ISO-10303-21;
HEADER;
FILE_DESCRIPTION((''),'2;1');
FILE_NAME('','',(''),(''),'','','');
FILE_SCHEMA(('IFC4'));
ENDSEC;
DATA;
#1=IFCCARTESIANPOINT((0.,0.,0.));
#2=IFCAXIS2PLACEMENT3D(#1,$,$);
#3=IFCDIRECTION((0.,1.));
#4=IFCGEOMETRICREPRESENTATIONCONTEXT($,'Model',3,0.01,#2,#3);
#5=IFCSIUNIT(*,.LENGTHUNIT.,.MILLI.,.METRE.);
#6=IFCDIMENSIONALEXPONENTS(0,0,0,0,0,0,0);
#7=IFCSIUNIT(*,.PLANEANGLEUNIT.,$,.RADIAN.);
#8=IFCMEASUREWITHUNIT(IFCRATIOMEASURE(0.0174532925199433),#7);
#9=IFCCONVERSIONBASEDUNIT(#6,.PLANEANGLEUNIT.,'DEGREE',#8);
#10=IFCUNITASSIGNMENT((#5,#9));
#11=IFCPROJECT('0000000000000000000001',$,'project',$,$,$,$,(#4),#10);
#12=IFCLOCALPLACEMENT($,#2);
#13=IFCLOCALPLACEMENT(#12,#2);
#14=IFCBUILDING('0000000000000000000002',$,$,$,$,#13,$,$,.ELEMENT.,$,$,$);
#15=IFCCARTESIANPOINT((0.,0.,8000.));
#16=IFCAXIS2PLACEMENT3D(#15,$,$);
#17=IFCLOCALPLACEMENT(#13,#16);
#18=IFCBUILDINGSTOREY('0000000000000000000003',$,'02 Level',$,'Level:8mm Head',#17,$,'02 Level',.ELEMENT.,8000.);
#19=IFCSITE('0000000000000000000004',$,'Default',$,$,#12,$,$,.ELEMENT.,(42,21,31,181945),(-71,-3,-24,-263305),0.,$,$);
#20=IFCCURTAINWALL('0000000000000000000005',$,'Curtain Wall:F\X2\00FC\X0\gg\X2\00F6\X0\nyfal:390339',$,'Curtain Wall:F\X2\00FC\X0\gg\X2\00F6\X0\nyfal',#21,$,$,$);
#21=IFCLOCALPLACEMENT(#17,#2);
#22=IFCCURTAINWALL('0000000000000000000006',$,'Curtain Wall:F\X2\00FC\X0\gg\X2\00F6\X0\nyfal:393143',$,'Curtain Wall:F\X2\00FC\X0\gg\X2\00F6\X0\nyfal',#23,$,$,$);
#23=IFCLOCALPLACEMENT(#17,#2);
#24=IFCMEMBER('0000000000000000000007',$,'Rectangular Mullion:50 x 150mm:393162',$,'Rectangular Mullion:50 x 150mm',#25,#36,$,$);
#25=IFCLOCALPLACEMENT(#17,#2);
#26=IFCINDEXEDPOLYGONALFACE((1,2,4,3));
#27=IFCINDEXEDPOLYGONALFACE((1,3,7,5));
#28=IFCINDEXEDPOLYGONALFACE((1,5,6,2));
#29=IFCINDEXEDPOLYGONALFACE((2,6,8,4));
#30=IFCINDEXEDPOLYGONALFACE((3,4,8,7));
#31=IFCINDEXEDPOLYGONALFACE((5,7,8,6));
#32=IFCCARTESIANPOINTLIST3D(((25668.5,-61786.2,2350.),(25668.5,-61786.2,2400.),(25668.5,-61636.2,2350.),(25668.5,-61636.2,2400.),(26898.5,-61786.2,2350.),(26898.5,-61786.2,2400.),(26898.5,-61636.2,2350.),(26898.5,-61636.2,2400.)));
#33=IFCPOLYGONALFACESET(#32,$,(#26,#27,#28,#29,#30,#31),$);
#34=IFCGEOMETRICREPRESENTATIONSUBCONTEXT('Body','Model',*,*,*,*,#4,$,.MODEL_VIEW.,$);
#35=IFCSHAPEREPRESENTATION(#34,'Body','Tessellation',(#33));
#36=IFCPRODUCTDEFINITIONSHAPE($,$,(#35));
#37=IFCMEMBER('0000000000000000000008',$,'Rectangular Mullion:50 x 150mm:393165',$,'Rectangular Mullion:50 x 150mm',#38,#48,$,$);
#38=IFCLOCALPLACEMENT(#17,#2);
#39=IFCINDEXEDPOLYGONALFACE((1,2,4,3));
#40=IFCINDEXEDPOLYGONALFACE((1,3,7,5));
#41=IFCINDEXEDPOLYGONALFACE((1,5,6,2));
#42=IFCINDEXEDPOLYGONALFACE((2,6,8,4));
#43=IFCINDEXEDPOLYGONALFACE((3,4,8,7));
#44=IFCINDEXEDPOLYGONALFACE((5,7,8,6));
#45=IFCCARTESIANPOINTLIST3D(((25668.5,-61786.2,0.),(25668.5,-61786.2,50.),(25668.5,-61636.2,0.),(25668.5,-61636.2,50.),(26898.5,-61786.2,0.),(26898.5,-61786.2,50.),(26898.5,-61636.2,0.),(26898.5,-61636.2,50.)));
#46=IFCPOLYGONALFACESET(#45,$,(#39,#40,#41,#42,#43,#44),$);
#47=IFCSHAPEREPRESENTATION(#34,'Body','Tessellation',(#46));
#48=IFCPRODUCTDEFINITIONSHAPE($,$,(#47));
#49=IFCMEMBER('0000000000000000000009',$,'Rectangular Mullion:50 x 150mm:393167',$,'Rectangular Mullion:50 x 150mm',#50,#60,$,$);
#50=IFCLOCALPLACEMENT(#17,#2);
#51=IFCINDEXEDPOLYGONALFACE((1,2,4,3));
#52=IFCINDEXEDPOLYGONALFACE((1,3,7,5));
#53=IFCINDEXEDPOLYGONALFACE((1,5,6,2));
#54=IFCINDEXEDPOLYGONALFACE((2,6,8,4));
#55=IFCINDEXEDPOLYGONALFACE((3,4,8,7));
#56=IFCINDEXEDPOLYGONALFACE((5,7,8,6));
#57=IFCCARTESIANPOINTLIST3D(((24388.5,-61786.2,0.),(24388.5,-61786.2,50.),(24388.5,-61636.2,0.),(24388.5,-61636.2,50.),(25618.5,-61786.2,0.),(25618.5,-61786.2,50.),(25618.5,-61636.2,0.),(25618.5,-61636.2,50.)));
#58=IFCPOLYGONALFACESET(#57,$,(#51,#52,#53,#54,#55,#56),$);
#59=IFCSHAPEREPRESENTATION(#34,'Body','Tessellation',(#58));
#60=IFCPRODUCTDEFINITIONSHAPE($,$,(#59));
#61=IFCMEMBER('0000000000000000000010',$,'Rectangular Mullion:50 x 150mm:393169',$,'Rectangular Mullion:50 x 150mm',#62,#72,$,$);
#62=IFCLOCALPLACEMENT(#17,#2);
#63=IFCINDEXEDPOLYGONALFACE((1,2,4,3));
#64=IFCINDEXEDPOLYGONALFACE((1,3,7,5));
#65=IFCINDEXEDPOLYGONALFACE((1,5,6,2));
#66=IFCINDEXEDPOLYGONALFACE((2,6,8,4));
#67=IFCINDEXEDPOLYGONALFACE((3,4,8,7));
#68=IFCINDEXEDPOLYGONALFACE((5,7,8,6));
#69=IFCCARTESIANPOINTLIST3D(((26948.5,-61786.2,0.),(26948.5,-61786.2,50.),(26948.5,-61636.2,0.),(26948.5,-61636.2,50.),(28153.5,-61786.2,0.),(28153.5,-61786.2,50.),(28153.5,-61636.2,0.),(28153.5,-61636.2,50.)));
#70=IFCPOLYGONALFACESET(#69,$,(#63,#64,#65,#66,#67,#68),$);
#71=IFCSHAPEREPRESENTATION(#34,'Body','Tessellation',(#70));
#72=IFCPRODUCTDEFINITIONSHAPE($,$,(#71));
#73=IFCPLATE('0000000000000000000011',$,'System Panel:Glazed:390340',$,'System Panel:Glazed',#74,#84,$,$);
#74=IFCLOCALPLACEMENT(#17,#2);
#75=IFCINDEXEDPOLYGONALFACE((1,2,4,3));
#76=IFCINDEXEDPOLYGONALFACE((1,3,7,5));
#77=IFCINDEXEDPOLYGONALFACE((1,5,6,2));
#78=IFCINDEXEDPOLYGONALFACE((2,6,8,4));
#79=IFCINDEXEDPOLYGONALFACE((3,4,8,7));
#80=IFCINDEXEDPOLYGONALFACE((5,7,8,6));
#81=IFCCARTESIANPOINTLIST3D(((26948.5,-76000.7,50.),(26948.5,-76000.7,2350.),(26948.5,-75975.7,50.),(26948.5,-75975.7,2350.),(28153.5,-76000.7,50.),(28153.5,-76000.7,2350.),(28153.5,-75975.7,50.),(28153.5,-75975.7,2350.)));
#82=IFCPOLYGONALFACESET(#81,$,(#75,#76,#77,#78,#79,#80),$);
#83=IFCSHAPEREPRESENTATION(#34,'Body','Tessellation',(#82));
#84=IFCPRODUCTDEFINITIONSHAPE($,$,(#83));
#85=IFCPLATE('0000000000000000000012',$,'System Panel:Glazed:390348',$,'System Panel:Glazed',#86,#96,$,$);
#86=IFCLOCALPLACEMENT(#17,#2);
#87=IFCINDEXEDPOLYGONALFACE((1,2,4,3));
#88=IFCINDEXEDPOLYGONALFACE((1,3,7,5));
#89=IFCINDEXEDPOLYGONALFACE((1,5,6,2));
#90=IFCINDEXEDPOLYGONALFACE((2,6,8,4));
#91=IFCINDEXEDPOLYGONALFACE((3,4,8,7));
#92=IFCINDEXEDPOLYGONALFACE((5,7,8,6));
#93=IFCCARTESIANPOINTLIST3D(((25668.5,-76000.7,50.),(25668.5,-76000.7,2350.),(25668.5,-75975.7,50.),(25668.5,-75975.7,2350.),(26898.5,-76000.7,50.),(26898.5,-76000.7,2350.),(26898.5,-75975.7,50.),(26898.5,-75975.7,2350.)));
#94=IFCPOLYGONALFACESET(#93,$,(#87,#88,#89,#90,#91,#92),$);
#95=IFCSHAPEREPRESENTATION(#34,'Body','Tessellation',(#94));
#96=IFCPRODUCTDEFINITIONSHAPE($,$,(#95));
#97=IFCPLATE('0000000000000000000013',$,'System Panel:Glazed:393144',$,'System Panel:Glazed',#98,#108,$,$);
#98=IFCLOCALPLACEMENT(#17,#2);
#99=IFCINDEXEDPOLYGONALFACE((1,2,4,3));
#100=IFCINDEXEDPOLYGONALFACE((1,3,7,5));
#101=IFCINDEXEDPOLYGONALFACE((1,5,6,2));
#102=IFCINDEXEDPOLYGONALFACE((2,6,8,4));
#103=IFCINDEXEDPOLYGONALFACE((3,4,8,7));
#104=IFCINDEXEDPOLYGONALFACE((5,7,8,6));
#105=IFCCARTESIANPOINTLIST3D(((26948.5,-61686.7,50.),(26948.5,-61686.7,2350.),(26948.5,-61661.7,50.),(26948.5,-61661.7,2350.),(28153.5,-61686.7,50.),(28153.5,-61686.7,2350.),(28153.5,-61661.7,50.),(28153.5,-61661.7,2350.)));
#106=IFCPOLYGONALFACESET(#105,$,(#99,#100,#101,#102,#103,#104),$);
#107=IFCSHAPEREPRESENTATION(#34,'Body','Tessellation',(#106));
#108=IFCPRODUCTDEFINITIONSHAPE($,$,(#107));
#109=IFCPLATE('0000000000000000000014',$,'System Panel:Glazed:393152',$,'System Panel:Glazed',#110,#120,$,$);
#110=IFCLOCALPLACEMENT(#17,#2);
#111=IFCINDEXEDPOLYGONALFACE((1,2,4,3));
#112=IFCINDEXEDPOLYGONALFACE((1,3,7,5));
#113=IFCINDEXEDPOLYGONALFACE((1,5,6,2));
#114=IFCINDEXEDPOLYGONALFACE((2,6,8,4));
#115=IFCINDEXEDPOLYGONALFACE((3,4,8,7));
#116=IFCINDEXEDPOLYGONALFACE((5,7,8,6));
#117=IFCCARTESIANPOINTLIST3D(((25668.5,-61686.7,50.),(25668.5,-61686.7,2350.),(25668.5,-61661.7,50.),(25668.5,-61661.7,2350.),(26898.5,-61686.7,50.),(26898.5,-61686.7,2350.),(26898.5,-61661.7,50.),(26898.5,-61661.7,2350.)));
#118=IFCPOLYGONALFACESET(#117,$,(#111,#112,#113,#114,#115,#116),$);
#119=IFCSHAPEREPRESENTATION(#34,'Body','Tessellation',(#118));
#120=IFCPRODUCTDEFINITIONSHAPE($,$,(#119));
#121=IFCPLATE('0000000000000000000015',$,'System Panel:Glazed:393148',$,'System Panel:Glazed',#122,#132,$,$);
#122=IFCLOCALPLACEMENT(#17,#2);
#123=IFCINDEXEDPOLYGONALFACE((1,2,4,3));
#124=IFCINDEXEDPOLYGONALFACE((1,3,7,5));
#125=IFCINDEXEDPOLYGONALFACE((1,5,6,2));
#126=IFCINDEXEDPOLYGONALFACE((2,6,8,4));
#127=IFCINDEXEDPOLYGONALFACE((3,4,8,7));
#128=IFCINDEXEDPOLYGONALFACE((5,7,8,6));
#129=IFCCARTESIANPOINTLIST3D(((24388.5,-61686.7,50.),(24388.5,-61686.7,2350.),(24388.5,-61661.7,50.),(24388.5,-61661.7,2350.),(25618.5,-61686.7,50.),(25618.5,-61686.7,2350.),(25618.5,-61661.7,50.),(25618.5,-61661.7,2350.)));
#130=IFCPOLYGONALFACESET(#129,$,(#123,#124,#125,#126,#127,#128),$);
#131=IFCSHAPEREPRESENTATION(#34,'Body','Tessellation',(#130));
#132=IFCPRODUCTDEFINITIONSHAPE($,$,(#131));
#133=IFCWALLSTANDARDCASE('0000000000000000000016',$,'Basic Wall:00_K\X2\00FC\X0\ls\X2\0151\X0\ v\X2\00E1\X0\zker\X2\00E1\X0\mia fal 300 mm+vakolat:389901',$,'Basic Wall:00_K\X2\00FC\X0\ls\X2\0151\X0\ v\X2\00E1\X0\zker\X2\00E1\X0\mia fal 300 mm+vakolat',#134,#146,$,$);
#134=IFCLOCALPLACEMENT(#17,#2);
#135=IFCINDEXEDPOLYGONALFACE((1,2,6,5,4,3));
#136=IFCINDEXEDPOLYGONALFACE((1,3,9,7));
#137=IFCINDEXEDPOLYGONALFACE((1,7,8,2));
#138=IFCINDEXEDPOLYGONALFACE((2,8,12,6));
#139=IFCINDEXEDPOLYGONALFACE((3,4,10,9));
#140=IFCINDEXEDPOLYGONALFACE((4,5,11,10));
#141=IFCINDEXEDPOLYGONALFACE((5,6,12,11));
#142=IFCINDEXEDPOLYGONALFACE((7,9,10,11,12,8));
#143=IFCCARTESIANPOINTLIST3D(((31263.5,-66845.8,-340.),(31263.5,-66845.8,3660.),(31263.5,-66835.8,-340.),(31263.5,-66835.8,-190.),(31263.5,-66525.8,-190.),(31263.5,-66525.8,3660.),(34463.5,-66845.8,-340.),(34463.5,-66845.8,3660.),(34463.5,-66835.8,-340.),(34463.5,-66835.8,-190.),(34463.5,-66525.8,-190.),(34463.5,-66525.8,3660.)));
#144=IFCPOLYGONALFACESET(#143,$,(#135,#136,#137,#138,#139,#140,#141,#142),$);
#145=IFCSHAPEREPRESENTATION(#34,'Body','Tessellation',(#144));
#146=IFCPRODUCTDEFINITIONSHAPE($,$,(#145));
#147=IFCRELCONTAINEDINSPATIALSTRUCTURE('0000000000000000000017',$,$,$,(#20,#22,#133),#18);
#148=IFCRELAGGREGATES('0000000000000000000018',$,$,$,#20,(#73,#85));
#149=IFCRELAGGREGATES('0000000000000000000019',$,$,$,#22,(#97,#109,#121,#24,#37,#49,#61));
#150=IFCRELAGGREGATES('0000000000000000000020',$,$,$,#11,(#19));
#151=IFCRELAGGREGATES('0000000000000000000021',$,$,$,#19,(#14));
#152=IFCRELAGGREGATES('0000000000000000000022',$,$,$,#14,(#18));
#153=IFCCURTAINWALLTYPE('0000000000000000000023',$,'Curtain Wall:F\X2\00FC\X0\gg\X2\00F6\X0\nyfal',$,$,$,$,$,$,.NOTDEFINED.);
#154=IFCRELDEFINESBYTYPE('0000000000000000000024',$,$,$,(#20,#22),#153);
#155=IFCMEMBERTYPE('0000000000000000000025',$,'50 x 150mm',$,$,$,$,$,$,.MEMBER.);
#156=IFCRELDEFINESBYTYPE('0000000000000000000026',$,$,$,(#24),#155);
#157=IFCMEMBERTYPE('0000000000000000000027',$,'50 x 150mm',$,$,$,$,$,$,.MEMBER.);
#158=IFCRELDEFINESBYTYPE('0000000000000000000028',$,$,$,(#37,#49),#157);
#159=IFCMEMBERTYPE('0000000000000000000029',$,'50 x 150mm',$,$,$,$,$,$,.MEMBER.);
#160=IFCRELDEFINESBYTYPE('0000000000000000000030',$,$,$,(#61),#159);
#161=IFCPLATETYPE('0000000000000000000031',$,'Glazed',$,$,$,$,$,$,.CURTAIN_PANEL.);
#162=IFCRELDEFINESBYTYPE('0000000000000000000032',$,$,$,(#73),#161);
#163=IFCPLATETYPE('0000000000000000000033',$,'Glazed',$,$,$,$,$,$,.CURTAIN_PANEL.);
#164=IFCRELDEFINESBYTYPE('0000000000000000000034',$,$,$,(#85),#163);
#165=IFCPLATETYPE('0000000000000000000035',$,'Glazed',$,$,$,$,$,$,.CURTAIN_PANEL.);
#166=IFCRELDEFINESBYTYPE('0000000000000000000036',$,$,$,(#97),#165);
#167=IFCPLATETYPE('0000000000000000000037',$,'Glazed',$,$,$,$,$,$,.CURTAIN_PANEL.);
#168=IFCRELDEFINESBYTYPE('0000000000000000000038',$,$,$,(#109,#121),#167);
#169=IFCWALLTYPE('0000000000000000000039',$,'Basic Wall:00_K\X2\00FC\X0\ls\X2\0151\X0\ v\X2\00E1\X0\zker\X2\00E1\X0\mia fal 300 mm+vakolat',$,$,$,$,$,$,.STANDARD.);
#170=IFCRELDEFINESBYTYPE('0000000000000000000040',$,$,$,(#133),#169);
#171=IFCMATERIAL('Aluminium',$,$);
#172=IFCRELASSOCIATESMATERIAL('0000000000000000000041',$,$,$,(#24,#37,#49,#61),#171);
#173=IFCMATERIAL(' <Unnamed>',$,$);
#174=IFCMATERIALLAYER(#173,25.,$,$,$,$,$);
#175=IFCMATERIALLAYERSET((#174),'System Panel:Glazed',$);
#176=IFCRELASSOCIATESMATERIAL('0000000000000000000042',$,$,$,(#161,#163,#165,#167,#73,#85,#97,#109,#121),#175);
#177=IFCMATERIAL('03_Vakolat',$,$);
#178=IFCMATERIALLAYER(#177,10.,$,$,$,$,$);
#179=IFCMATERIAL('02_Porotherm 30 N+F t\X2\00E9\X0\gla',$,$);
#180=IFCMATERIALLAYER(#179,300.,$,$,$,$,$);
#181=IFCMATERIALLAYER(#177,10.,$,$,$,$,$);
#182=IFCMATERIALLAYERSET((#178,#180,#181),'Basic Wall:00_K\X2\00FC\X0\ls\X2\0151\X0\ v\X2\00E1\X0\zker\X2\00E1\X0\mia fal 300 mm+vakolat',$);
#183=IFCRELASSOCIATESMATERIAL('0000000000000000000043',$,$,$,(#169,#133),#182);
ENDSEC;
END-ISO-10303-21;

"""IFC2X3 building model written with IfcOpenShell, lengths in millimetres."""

from ifc_helpers import new_model, entity, si_unit, converted_unit, direction, frame, frame_2d, origin, origin_2d_with_axis, place, context, subcontext, project, spatial, polyline, rectangle, extrude, clip, bounded_halfspace, source, transform, mapped, material, layer, layer_set, layer_usage, type_object, type_shapes, element, aggregate, save


model = new_model("IFC2X3")

# Units and contexts
model_context = context("Model", 3, precision=0.01, world=origin(), true_north=direction((0.0, 1.0)))
body_context = subcontext(model_context, "Body", "Model", "MODEL_VIEW")
ifc_project = project(units=[si_unit("LENGTHUNIT", "METRE", prefix="MILLI"), converted_unit("PLANEANGLEUNIT", "DEGREE", entity("IfcRatioMeasure", 0.0174532925199433), si_unit("PLANEANGLEUNIT", "RADIAN"), dimensions=[0, 0, 0, 0, 0, 0, 0])], contexts=[model_context])

# Site, building, storey
site_placement = place(None, origin())
site = spatial("IfcSite", under=ifc_project, at=site_placement, Name="Default", CompositionType="ELEMENT", RefLatitude=(42, 21, 31, 181945), RefLongitude=(-71, -3, -24, -263305), RefElevation=0.0)
building_placement = place(site_placement, origin())
building = spatial("IfcBuilding", under=site, at=building_placement, CompositionType="ELEMENT")
storey_placement = place(building_placement, frame((0.0, 0.0, 8000.0)))
storey = spatial("IfcBuildingStorey", under=building, at=storey_placement, Name="02 Level", ObjectType="Level:8mm Head", LongName="02 Level", CompositionType="ELEMENT", Elevation=8000.0)

# Curtain walls, members
curtain_wall_type = type_object("IfcCurtainWallType", Name="Curtain Wall:Függönyfal", PredefinedType="NOTDEFINED")
curtain_wall_1_placement = place(storey_placement, frame((0.0, 0.0, -8000.0)))
curtain_wall_1 = element("IfcCurtainWall", 1, at=curtain_wall_1_placement, inside=storey, type_object=curtain_wall_type, Name="Curtain Wall:Függönyfal:390339", ObjectType="Curtain Wall:Függönyfal")
ifc_material_1 = material(Name="Aluminium")
curtain_wall_2_placement = place(storey_placement, frame((0.0, 0.0, -8000.0)))
curtain_wall_2 = element("IfcCurtainWall", 2, at=curtain_wall_2_placement, inside=storey, type_object=curtain_wall_type, Name="Curtain Wall:Függönyfal:393143", ObjectType="Curtain Wall:Függönyfal")
member_type_1 = type_object("IfcMemberType", Name="50 x 150mm", PredefinedType="MEMBER")
shared_shape_1 = source(origin(), body_context, "Body", "SweptSolid", [
    extrude(rectangle(XDim=150.0, YDim=50.0, at=origin_2d_with_axis()), frame((-25.0, 0.0, -1230.0), z_axis=(0.0, 0.0, 1.0), x_axis=(0.0, -1.0, 0.0)), (0.0, 0.0, 1.0), 1230.0),
])
type_shapes(member_type_1, [shared_shape_1])
member_1_placement = place(storey_placement, frame((25668.5, -61711.2, 2400.0), z_axis=(-1.0, 0.0, 0.0), x_axis=(0.0, 0.0, 1.0)))
member_1 = element("IfcMember", 3, at=member_1_placement, type_object=member_type_1, material=ifc_material_1, Name="Rectangular Mullion:50 x 150mm:393162", ObjectType="Rectangular Mullion:50 x 150mm", context=body_context, shape_type="MappedRepresentation", body=[
    mapped(shared_shape_1, transform((0.0, 0.0, 0.0), scale=1.0)),
])
member_type_2 = type_object("IfcMemberType", Name="50 x 150mm", PredefinedType="MEMBER")
shared_shape_2 = source(origin(), body_context, "Body", "SweptSolid", [
    extrude(rectangle(XDim=150.0, YDim=50.0, at=origin_2d_with_axis()), frame((-25.0, 0.0, -1230.0), z_axis=(0.0, 0.0, 1.0), x_axis=(0.0, -1.0, 0.0)), (0.0, 0.0, 1.0), 1230.0),
])
type_shapes(member_type_2, [shared_shape_2])
member_2_placement = place(storey_placement, frame((26898.5, -61711.2, 0.0), z_axis=(1.0, 0.0, 0.0), x_axis=(0.0, 0.0, -1.0)))
member_2 = element("IfcMember", 4, at=member_2_placement, type_object=member_type_2, material=ifc_material_1, Name="Rectangular Mullion:50 x 150mm:393165", ObjectType="Rectangular Mullion:50 x 150mm", context=body_context, shape_type="MappedRepresentation", body=[
    mapped(shared_shape_2, transform((0.0, 0.0, 0.0), scale=1.0)),
])
member_3_placement = place(storey_placement, frame((25618.5, -61711.2, 0.0), z_axis=(1.0, 0.0, 0.0), x_axis=(0.0, 0.0, -1.0)))
member_3 = element("IfcMember", 5, at=member_3_placement, type_object=member_type_2, material=ifc_material_1, Name="Rectangular Mullion:50 x 150mm:393167", ObjectType="Rectangular Mullion:50 x 150mm", context=body_context, shape_type="MappedRepresentation", body=[
    mapped(shared_shape_2, transform((0.0, 0.0, 0.0), scale=1.0)),
])
member_type_3 = type_object("IfcMemberType", Name="50 x 150mm", PredefinedType="MEMBER")
shared_shape_3 = source(origin(), body_context, "Body", "SweptSolid", [
    extrude(rectangle(XDim=150.0, YDim=50.0, at=origin_2d_with_axis()), frame((-25.0, 0.0, -1205.0), z_axis=(0.0, 0.0, 1.0), x_axis=(0.0, -1.0, 0.0)), (0.0, 0.0, 1.0), 1205.0),
])
type_shapes(member_type_3, [shared_shape_3])
member_4_placement = place(storey_placement, frame((28153.5, -61711.2, 0.0), z_axis=(1.0, 0.0, 0.0), x_axis=(0.0, 0.0, -1.0)))
member_4 = element("IfcMember", 6, at=member_4_placement, type_object=member_type_3, material=ifc_material_1, Name="Rectangular Mullion:50 x 150mm:393169", ObjectType="Rectangular Mullion:50 x 150mm", context=body_context, shape_type="MappedRepresentation", body=[
    mapped(shared_shape_3, transform((0.0, 0.0, 0.0), scale=1.0)),
])

# Plates
ifc_material_2 = material(Name=" <Unnamed>")
ifc_layer_1 = layer(ifc_material_2, 25.0)
ifc_layer_set_1 = layer_set([ifc_layer_1], Name="System Panel:Glazed")
ifc_layer_usage_1 = layer_usage(ifc_layer_set_1, "AXIS3", "POSITIVE", 0.1)
plate_type_1 = type_object("IfcPlateType", Name="Glazed", PredefinedType="CURTAIN_PANEL", material=ifc_layer_set_1)
shared_shape_4 = source(origin(), body_context, "Body", "SweptSolid", [
    extrude(rectangle(XDim=25.0, YDim=1205.0, at=origin_2d_with_axis()), frame((602.5, 12.5, 0.0), z_axis=(0.0, 0.0, 1.0), x_axis=(0.0, 1.0, 0.0)), (0.0, 0.0, 1.0), 2300.0),
])
type_shapes(plate_type_1, [shared_shape_4])
plate_1_placement = place(curtain_wall_1_placement, frame((28153.5, -75975.7, 8050.0), z_axis=(0.0, 0.0, 1.0), x_axis=(-1.0, 0.0, 0.0)))
plate_1 = element("IfcPlate", 7, at=plate_1_placement, type_object=plate_type_1, material=ifc_layer_usage_1, Name="System Panel:Glazed:390340", ObjectType="System Panel:Glazed", context=body_context, shape_type="MappedRepresentation", body=[
    mapped(shared_shape_4, transform((0.0, 0.0, 0.0), scale=1.0)),
])
ifc_layer_usage_2 = layer_usage(ifc_layer_set_1, "AXIS3", "POSITIVE", 0.1)
plate_type_2 = type_object("IfcPlateType", Name="Glazed", PredefinedType="CURTAIN_PANEL", material=ifc_layer_set_1)
shared_shape_5 = source(origin(), body_context, "Body", "SweptSolid", [
    extrude(rectangle(XDim=25.0, YDim=1230.0, at=origin_2d_with_axis()), frame((615.0, 12.5, 0.0), z_axis=(0.0, 0.0, 1.0), x_axis=(0.0, 1.0, 0.0)), (0.0, 0.0, 1.0), 2300.0),
])
type_shapes(plate_type_2, [shared_shape_5])
plate_2_placement = place(curtain_wall_1_placement, frame((26898.5, -75975.7, 8050.0), z_axis=(0.0, 0.0, 1.0), x_axis=(-1.0, 0.0, 0.0)))
plate_2 = element("IfcPlate", 8, at=plate_2_placement, type_object=plate_type_2, material=ifc_layer_usage_2, Name="System Panel:Glazed:390348", ObjectType="System Panel:Glazed", context=body_context, shape_type="MappedRepresentation", body=[
    mapped(shared_shape_5, transform((0.0, 0.0, 0.0), scale=1.0)),
])
aggregate(curtain_wall_1, [plate_1, plate_2])
ifc_layer_usage_3 = layer_usage(ifc_layer_set_1, "AXIS3", "POSITIVE", 0.1)
plate_type_3 = type_object("IfcPlateType", Name="Glazed", PredefinedType="CURTAIN_PANEL", material=ifc_layer_set_1)
shared_shape_6 = source(origin(), body_context, "Body", "SweptSolid", [
    extrude(rectangle(XDim=25.0, YDim=1205.0, at=frame_2d((0.0, 0.0), x_axis=(1.0, 0.0))), frame((602.5, 12.5, 0.0), z_axis=(0.0, 0.0, 1.0), x_axis=(0.0, 1.0, 0.0)), (0.0, 0.0, 1.0), 2300.0),
])
type_shapes(plate_type_3, [shared_shape_6])
plate_3_placement = place(curtain_wall_2_placement, frame((28153.5, -61661.7, 8050.0), z_axis=(0.0, 0.0, 1.0), x_axis=(-1.0, 0.0, 0.0)))
plate_3 = element("IfcPlate", 9, at=plate_3_placement, type_object=plate_type_3, material=ifc_layer_usage_3, Name="System Panel:Glazed:393144", ObjectType="System Panel:Glazed", context=body_context, shape_type="MappedRepresentation", body=[
    mapped(shared_shape_6, transform((0.0, 0.0, 0.0), scale=1.0)),
])
ifc_layer_usage_4 = layer_usage(ifc_layer_set_1, "AXIS3", "POSITIVE", 0.1)
plate_type_4 = type_object("IfcPlateType", Name="Glazed", PredefinedType="CURTAIN_PANEL", material=ifc_layer_set_1)
shared_shape_7 = source(origin(), body_context, "Body", "SweptSolid", [
    extrude(rectangle(XDim=25.0, YDim=1230.0, at=frame_2d((0.0, 0.0), x_axis=(1.0, 0.0))), frame((615.0, 12.5, 0.0), z_axis=(0.0, 0.0, 1.0), x_axis=(0.0, 1.0, 0.0)), (0.0, 0.0, 1.0), 2300.0),
])
type_shapes(plate_type_4, [shared_shape_7])
plate_4_placement = place(curtain_wall_2_placement, frame((26898.5, -61661.7, 8050.0), z_axis=(0.0, 0.0, 1.0), x_axis=(-1.0, 0.0, 0.0)))
plate_4 = element("IfcPlate", 10, at=plate_4_placement, type_object=plate_type_4, material=ifc_layer_usage_4, Name="System Panel:Glazed:393152", ObjectType="System Panel:Glazed", context=body_context, shape_type="MappedRepresentation", body=[
    mapped(shared_shape_7, transform((0.0, 0.0, 0.0), scale=1.0)),
])
ifc_layer_usage_5 = layer_usage(ifc_layer_set_1, "AXIS3", "POSITIVE", 0.1)
plate_5_placement = place(curtain_wall_2_placement, frame((25618.5, -61661.7, 8050.0), z_axis=(0.0, 0.0, 1.0), x_axis=(-1.0, 0.0, 0.0)))
plate_5 = element("IfcPlate", 11, at=plate_5_placement, type_object=plate_type_4, material=ifc_layer_usage_5, Name="System Panel:Glazed:393148", ObjectType="System Panel:Glazed", context=body_context, shape_type="MappedRepresentation", body=[
    mapped(shared_shape_7, transform((0.0, 0.0, 0.0), scale=1.0)),
])
aggregate(curtain_wall_2, [plate_3, plate_4, plate_5, member_1, member_2, member_3, member_4])

# Wall
ifc_material_3 = material(Name="03_Vakolat")
ifc_layer_2 = layer(ifc_material_3, 10.0)
ifc_material_4 = material(Name="02_Porotherm 30 N+F tégla")
ifc_layer_3 = layer(ifc_material_4, 300.0)
ifc_layer_4 = layer(ifc_material_3, 10.0)
ifc_layer_set_2 = layer_set([ifc_layer_2, ifc_layer_3, ifc_layer_4], Name="Basic Wall:00_Külső vázkerámia fal 300 mm+vakolat")
ifc_layer_usage_6 = layer_usage(ifc_layer_set_2, "AXIS2", "NEGATIVE", 160.0)
wall_type_1 = type_object("IfcWallType", Name="Basic Wall:00_Külső vázkerámia fal 300 mm+vakolat", PredefinedType="STANDARD", material=ifc_layer_set_2)
wall_1_placement = place(storey_placement, frame((31263.5, -66685.8, -340.0)))
element("IfcWallStandardCase", 12, at=wall_1_placement, inside=storey, type_object=wall_type_1, material=ifc_layer_usage_6, Name="Basic Wall:00_Külső vázkerámia fal 300 mm+vakolat:389901", ObjectType="Basic Wall:00_Külső vázkerámia fal 300 mm+vakolat", context=body_context, shape_type="Clipping", body=[
    clip(clip(extrude(rectangle(XDim=3200.0, YDim=320.0, at=frame_2d((1600.0, 0.0), x_axis=(-1.0, 0.0))), origin(), (0.0, 0.0, 1.0), 4000.0), bounded_halfspace(frame((3200.0, -150.0, 150.0), z_axis=(0.0, 0.0, 1.0), x_axis=(0.0, 1.0, 0.0)), True, frame((3200.0, -150.0, 150.0), z_axis=(0.0, 0.0, 1.0), x_axis=(0.0, 1.0, 0.0)), polyline([(0.0, 0.0), (310.0, 0.0), (310.0, 3200.0), (0.0, 3200.0), (0.0, 0.0)]))), bounded_halfspace(frame((0.0, -150.0, 150.0), z_axis=(0.0, -1.0, 0.0), x_axis=(0.0, 0.0, 1.0)), True, frame((0.0, -150.0, 150.0), z_axis=(0.0, -1.0, 0.0), x_axis=(0.0, 0.0, 1.0)), polyline([(0.0, 0.0), (-150.0, 0.0), (-150.0, -3200.0), (0.0, -3200.0), (0.0, 0.0)]))),
])

save(model, "model.ifc")
